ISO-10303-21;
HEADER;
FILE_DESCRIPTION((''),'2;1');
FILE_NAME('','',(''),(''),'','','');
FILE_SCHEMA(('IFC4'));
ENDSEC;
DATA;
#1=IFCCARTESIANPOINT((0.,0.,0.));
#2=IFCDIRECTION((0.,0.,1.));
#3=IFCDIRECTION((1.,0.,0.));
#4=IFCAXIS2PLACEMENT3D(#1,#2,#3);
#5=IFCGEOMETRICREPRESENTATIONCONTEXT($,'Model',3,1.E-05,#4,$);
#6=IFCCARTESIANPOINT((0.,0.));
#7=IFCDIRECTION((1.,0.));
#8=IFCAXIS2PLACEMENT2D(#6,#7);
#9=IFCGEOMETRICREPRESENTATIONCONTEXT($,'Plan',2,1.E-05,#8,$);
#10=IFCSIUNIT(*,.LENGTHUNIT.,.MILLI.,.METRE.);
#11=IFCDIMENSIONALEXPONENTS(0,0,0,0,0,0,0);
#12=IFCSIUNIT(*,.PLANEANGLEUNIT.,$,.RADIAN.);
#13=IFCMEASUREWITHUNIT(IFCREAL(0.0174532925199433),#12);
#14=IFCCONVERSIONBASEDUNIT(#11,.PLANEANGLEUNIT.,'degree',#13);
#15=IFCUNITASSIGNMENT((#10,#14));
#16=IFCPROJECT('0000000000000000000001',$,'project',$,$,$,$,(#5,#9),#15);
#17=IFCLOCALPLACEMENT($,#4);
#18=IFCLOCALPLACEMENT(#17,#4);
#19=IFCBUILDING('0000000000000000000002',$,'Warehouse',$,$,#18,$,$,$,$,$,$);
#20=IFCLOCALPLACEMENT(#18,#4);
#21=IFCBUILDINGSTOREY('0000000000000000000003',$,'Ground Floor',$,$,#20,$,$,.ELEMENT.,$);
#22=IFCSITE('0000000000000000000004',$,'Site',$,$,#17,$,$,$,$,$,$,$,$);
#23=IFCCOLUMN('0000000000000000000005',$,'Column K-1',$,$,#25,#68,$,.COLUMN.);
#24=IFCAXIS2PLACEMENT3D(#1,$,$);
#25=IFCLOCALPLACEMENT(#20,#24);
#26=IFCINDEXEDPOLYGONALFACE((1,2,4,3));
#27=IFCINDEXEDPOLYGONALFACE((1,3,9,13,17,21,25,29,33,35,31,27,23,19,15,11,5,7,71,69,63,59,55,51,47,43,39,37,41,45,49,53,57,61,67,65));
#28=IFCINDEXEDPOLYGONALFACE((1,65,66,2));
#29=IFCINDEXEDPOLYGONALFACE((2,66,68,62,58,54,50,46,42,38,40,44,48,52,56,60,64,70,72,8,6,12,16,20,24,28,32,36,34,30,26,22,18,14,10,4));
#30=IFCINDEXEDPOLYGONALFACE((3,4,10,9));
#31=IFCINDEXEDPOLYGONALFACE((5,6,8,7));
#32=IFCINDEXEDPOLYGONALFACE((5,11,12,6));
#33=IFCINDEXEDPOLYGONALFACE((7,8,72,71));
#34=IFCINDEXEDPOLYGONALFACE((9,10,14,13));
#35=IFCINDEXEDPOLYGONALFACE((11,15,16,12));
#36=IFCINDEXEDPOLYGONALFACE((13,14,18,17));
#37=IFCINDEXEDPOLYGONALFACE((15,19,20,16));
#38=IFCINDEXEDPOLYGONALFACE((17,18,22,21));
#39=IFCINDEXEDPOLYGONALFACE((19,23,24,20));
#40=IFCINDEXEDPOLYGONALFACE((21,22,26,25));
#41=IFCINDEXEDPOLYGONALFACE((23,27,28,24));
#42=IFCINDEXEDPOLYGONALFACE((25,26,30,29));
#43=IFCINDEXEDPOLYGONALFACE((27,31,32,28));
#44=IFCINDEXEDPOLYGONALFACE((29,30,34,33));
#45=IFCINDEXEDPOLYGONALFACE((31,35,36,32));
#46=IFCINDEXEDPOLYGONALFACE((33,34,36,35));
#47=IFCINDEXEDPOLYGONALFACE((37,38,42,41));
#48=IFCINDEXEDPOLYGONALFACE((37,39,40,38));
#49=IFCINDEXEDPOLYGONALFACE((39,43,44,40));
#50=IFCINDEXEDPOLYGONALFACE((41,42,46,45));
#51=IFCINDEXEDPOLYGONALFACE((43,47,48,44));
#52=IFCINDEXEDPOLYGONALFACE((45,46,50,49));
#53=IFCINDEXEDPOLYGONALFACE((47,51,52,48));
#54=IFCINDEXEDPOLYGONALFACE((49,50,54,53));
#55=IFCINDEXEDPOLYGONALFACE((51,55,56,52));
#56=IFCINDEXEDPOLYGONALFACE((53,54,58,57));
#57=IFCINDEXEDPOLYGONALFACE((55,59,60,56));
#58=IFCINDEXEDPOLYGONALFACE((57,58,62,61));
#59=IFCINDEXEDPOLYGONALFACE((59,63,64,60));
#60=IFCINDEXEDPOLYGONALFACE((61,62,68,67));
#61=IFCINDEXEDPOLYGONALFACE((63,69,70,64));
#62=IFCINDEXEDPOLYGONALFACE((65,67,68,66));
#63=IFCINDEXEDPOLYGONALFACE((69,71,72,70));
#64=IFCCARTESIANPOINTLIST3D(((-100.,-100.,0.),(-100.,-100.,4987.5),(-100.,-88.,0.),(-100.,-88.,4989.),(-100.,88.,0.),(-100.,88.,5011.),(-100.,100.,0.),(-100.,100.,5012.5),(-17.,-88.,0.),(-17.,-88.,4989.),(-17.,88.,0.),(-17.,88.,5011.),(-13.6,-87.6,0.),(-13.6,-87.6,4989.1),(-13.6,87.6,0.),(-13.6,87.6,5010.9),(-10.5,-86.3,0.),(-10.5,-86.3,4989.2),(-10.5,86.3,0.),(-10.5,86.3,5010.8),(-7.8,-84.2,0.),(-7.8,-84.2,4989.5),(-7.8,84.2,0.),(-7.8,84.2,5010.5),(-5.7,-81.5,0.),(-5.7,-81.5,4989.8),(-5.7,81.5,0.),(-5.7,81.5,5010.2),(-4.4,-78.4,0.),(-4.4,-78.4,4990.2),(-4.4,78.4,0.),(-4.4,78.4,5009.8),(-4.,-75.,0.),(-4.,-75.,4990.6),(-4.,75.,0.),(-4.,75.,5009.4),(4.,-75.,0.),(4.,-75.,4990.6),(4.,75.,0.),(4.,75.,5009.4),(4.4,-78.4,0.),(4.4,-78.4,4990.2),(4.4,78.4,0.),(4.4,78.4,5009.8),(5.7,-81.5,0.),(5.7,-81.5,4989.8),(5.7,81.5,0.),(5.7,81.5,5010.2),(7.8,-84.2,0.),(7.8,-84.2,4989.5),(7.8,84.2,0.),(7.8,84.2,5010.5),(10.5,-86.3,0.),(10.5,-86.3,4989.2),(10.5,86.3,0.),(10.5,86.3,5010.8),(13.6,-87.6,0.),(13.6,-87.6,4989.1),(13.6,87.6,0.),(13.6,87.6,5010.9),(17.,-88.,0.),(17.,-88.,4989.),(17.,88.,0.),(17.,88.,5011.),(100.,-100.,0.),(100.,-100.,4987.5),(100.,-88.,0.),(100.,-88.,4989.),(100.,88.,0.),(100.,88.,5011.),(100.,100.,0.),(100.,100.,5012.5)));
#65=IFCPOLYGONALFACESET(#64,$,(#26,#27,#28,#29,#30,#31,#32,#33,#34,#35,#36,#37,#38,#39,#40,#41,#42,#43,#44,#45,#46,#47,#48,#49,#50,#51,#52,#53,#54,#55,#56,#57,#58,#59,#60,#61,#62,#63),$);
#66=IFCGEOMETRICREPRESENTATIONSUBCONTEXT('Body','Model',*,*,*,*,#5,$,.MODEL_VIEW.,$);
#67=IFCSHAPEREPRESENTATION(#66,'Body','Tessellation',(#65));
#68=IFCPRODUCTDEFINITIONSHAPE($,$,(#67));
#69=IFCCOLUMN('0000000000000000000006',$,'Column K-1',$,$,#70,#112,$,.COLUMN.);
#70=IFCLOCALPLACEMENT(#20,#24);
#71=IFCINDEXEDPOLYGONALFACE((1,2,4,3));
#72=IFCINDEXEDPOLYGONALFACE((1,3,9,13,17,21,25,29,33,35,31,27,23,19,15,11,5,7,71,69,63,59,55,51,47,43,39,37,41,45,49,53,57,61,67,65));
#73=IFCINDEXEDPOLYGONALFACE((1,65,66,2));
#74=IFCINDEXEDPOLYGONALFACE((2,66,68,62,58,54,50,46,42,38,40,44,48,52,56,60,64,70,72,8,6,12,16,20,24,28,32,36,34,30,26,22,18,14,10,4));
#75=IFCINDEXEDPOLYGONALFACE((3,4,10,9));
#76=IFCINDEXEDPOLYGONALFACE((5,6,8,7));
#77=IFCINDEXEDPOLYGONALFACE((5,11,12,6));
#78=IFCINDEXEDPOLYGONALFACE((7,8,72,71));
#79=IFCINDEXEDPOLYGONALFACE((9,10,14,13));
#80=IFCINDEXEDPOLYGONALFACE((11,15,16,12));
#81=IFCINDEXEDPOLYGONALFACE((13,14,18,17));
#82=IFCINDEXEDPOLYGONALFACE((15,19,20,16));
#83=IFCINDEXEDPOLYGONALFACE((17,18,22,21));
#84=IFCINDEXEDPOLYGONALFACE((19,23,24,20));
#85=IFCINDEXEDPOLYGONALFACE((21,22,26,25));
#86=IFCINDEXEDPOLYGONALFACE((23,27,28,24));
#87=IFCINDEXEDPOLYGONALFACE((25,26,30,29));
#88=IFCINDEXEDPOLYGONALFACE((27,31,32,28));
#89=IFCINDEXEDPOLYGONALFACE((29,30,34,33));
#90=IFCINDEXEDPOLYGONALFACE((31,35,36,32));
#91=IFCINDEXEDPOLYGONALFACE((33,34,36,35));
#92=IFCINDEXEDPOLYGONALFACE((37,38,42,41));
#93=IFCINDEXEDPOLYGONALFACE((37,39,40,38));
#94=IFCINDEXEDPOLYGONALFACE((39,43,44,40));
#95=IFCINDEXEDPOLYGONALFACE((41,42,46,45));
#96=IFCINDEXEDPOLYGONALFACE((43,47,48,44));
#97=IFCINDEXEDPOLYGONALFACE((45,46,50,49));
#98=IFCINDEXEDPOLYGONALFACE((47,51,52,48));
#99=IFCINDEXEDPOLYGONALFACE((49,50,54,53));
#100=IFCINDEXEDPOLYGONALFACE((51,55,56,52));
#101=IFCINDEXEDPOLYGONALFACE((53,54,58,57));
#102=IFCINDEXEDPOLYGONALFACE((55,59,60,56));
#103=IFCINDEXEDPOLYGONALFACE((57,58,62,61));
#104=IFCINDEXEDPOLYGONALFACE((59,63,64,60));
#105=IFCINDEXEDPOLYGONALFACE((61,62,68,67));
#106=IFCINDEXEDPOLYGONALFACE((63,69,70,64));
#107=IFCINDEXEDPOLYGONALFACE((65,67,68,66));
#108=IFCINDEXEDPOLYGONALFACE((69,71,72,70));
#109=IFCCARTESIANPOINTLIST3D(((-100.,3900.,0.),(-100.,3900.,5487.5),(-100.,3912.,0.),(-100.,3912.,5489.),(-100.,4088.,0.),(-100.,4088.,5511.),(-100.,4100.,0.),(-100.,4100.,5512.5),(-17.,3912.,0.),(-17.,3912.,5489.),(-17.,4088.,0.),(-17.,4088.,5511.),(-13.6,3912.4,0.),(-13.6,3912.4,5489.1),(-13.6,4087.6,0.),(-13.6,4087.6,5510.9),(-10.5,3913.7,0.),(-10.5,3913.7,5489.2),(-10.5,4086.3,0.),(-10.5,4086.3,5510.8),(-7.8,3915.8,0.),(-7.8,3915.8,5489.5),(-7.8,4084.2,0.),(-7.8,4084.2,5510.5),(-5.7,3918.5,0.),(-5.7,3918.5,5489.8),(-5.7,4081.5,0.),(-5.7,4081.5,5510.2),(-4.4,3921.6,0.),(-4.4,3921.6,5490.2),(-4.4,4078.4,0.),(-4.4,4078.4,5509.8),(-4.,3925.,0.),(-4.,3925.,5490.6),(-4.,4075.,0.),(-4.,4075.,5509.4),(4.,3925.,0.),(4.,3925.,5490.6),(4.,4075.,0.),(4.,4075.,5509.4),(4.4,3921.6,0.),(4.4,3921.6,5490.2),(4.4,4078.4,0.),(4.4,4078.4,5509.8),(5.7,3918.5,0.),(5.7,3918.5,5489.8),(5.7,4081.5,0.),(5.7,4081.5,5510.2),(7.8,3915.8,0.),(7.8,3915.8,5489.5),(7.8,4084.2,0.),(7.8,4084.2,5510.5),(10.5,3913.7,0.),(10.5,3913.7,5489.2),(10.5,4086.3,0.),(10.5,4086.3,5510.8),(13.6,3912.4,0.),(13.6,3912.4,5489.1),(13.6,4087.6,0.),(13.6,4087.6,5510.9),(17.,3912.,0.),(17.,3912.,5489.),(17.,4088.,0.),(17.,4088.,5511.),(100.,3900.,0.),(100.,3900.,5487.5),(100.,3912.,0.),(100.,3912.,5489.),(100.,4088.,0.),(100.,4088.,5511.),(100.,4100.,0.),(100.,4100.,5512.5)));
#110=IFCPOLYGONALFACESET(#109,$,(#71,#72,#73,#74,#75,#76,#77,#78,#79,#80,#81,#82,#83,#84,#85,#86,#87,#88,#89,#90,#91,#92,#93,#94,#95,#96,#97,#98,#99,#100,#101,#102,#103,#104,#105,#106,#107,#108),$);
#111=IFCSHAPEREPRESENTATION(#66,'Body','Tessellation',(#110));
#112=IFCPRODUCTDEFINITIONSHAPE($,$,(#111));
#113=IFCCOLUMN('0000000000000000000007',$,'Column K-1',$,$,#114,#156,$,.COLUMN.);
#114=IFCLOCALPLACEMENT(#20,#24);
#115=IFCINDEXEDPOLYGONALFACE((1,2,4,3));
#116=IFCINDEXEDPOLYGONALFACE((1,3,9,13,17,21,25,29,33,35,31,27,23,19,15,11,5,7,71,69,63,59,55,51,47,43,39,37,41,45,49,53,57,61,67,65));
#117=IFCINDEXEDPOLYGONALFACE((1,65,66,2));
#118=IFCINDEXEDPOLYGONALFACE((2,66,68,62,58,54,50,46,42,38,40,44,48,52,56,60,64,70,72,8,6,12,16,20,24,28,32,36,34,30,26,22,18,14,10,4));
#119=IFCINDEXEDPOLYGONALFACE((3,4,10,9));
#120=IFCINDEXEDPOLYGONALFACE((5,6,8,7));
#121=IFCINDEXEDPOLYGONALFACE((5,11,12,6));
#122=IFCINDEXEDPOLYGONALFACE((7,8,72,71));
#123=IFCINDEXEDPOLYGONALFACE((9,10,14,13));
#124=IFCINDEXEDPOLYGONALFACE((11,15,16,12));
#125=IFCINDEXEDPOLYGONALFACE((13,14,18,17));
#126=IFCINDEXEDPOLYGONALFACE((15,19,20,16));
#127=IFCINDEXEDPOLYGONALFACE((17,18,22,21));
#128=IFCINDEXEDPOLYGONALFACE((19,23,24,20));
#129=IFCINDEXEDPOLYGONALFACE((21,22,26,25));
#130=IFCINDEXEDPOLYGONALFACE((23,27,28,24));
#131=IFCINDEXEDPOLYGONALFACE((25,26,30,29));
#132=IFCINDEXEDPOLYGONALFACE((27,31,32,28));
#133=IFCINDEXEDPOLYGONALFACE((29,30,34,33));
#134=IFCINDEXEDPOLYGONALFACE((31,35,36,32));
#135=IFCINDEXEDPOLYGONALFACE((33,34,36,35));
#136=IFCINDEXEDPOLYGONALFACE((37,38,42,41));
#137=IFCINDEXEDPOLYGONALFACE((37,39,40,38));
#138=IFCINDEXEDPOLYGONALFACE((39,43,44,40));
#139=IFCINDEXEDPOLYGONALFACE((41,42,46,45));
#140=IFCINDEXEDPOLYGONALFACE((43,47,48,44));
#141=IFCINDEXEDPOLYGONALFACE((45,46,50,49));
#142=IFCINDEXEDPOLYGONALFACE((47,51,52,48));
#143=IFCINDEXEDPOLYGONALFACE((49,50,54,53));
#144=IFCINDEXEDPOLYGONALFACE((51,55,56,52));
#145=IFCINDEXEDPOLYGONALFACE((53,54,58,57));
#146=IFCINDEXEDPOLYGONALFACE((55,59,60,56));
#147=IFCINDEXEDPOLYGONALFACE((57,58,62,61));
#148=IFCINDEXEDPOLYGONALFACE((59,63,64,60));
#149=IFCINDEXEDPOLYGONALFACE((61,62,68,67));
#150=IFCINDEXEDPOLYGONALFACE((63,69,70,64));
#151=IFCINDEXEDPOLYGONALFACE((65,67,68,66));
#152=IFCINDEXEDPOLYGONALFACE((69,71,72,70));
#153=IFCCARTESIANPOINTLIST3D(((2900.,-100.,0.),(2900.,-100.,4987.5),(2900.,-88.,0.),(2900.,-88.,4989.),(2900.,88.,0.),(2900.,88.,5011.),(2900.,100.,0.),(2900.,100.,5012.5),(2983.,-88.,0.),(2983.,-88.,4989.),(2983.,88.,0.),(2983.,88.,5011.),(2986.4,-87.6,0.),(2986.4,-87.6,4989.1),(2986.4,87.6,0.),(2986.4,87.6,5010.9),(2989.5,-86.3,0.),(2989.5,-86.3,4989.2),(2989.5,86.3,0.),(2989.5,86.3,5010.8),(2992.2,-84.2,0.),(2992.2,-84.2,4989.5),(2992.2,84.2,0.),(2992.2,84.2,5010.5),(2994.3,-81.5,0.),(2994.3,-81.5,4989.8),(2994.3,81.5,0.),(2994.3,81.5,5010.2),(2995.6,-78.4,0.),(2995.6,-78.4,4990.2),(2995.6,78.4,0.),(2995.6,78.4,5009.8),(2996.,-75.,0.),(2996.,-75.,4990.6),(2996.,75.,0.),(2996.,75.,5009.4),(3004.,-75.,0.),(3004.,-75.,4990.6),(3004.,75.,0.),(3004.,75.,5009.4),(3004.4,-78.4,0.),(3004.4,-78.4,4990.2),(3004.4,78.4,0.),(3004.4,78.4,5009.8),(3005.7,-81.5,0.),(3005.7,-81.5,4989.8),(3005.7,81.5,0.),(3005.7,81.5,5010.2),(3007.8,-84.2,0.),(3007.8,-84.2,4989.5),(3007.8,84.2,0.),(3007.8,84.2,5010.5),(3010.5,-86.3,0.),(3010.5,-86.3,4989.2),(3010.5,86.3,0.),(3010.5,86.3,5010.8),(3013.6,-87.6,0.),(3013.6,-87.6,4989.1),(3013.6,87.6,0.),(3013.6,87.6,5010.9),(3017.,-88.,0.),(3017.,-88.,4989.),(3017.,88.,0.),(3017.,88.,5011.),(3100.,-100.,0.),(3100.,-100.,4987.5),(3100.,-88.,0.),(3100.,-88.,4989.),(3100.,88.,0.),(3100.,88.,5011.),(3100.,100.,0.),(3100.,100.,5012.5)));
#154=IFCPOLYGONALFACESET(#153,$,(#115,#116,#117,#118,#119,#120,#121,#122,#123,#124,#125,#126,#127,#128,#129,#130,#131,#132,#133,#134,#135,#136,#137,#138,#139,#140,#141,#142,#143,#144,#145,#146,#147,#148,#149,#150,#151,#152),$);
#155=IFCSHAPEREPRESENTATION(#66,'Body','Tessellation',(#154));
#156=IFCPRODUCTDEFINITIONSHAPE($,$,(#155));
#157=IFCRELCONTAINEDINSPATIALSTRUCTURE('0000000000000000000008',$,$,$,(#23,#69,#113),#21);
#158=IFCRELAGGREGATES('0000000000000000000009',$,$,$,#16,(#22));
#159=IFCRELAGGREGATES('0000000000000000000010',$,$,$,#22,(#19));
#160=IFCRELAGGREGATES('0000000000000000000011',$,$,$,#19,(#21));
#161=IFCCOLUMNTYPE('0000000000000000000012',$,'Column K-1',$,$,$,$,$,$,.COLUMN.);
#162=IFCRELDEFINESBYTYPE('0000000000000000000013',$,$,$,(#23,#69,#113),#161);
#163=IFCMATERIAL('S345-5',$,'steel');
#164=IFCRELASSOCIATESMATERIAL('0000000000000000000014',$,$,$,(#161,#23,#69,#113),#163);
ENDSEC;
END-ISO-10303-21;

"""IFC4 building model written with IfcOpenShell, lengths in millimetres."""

from ifc_helpers import new_model, entity, si_unit, converted_unit, frame, origin_with_axes, origin_2d_with_axis, place, context, subcontext, project, spatial, i_section, extrude, clip, halfspace, material, material_profile, profile_set, profile_usage, type_object, element, save


model = new_model("IFC4")

# Units and contexts
model_context = context("Model", 3, precision=1e-05, world=origin_with_axes())
plan_context = context("Plan", 2, precision=1e-05, world=origin_2d_with_axis())
body_context = subcontext(model_context, "Body", "Model", "MODEL_VIEW")
ifc_project = project(units=[si_unit("LENGTHUNIT", "METRE", prefix="MILLI"), converted_unit("PLANEANGLEUNIT", "degree", entity("IfcReal", 0.0174532925199433), si_unit("PLANEANGLEUNIT", "RADIAN"), dimensions=[0, 0, 0, 0, 0, 0, 0])], contexts=[model_context, plan_context])

# Site, building, storey
site_placement = place(None, origin_with_axes())
site = spatial("IfcSite", under=ifc_project, at=site_placement, Name="Site")
building_placement = place(site_placement, origin_with_axes())
building = spatial("IfcBuilding", under=site, at=building_placement, Name="Warehouse")
storey_placement = place(building_placement, origin_with_axes())
storey = spatial("IfcBuildingStorey", under=building, at=storey_placement, Name="Ground Floor", CompositionType="ELEMENT")

# Columns
ifc_material_1 = material(Name="S345-5", Category="steel")
ifc_material_profile_1 = material_profile(ifc_material_1, i_section(OverallWidth=200.0, OverallDepth=200.0, WebThickness=8.0, FlangeThickness=12.0, FilletRadius=13.0, FlangeEdgeRadius=0.0, FlangeSlope=0.0))
ifc_profile_set_1 = profile_set([ifc_material_profile_1], Name="I20K2_S345-5")
ifc_profile_usage_1 = profile_usage(ifc_profile_set_1, cardinal=5)
column_type = type_object("IfcColumnType", Name="Column K-1", PredefinedType="COLUMN", material=ifc_profile_set_1)
column_1_placement = place(storey_placement, origin_with_axes())
element("IfcColumn", 1, at=column_1_placement, inside=storey, type_object=column_type, material=ifc_profile_usage_1, Name="Column K-1", PredefinedType="COLUMN", context=body_context, shape_type="Clipping", body=[
    clip(extrude(i_section(OverallWidth=200.0, OverallDepth=200.0, WebThickness=8.0, FlangeThickness=12.0, FilletRadius=13.0, FlangeEdgeRadius=0.0, FlangeSlope=0.0), origin_with_axes(), (0.0, 0.0, 1.0), 5200.0), halfspace(frame((0.0, -298.5, 4962.7), z_axis=(0.0, -0.124035, 0.992278), x_axis=(0.0, 0.992278, 0.124035)), False)),
])
ifc_profile_usage_2 = profile_usage(ifc_profile_set_1, cardinal=5)
column_2_placement = place(storey_placement, frame((0.0, 4000.0, 0.0), z_axis=(0.0, 0.0, 1.0), x_axis=(1.0, 0.0, 0.0)))
element("IfcColumn", 2, at=column_2_placement, inside=storey, type_object=column_type, material=ifc_profile_usage_2, Name="Column K-1", PredefinedType="COLUMN", context=body_context, shape_type="Clipping", body=[
    clip(extrude(i_section(OverallWidth=200.0, OverallDepth=200.0, WebThickness=8.0, FlangeThickness=12.0, FilletRadius=13.0, FlangeEdgeRadius=0.0, FlangeSlope=0.0), origin_with_axes(), (0.0, 0.0, 1.0), 5700.0), halfspace(frame((0.0, -4298.5, 4962.7), z_axis=(0.0, -0.124035, 0.992278), x_axis=(0.0, 0.992278, 0.124035)), False)),
])
ifc_profile_usage_3 = profile_usage(ifc_profile_set_1, cardinal=5)
column_3_placement = place(storey_placement, frame((3000.0, 0.0, 0.0), z_axis=(0.0, 0.0, 1.0), x_axis=(1.0, 0.0, 0.0)))
element("IfcColumn", 3, at=column_3_placement, inside=storey, type_object=column_type, material=ifc_profile_usage_3, Name="Column K-1", PredefinedType="COLUMN", context=body_context, shape_type="Clipping", body=[
    clip(extrude(i_section(OverallWidth=200.0, OverallDepth=200.0, WebThickness=8.0, FlangeThickness=12.0, FilletRadius=13.0, FlangeEdgeRadius=0.0, FlangeSlope=0.0), origin_with_axes(), (0.0, 0.0, 1.0), 5200.0), halfspace(frame((0.0, -298.5, 4962.7), z_axis=(0.0, -0.124035, 0.992278), x_axis=(0.0, 0.992278, 0.124035)), False)),
])

save(model, "model.ifc")
